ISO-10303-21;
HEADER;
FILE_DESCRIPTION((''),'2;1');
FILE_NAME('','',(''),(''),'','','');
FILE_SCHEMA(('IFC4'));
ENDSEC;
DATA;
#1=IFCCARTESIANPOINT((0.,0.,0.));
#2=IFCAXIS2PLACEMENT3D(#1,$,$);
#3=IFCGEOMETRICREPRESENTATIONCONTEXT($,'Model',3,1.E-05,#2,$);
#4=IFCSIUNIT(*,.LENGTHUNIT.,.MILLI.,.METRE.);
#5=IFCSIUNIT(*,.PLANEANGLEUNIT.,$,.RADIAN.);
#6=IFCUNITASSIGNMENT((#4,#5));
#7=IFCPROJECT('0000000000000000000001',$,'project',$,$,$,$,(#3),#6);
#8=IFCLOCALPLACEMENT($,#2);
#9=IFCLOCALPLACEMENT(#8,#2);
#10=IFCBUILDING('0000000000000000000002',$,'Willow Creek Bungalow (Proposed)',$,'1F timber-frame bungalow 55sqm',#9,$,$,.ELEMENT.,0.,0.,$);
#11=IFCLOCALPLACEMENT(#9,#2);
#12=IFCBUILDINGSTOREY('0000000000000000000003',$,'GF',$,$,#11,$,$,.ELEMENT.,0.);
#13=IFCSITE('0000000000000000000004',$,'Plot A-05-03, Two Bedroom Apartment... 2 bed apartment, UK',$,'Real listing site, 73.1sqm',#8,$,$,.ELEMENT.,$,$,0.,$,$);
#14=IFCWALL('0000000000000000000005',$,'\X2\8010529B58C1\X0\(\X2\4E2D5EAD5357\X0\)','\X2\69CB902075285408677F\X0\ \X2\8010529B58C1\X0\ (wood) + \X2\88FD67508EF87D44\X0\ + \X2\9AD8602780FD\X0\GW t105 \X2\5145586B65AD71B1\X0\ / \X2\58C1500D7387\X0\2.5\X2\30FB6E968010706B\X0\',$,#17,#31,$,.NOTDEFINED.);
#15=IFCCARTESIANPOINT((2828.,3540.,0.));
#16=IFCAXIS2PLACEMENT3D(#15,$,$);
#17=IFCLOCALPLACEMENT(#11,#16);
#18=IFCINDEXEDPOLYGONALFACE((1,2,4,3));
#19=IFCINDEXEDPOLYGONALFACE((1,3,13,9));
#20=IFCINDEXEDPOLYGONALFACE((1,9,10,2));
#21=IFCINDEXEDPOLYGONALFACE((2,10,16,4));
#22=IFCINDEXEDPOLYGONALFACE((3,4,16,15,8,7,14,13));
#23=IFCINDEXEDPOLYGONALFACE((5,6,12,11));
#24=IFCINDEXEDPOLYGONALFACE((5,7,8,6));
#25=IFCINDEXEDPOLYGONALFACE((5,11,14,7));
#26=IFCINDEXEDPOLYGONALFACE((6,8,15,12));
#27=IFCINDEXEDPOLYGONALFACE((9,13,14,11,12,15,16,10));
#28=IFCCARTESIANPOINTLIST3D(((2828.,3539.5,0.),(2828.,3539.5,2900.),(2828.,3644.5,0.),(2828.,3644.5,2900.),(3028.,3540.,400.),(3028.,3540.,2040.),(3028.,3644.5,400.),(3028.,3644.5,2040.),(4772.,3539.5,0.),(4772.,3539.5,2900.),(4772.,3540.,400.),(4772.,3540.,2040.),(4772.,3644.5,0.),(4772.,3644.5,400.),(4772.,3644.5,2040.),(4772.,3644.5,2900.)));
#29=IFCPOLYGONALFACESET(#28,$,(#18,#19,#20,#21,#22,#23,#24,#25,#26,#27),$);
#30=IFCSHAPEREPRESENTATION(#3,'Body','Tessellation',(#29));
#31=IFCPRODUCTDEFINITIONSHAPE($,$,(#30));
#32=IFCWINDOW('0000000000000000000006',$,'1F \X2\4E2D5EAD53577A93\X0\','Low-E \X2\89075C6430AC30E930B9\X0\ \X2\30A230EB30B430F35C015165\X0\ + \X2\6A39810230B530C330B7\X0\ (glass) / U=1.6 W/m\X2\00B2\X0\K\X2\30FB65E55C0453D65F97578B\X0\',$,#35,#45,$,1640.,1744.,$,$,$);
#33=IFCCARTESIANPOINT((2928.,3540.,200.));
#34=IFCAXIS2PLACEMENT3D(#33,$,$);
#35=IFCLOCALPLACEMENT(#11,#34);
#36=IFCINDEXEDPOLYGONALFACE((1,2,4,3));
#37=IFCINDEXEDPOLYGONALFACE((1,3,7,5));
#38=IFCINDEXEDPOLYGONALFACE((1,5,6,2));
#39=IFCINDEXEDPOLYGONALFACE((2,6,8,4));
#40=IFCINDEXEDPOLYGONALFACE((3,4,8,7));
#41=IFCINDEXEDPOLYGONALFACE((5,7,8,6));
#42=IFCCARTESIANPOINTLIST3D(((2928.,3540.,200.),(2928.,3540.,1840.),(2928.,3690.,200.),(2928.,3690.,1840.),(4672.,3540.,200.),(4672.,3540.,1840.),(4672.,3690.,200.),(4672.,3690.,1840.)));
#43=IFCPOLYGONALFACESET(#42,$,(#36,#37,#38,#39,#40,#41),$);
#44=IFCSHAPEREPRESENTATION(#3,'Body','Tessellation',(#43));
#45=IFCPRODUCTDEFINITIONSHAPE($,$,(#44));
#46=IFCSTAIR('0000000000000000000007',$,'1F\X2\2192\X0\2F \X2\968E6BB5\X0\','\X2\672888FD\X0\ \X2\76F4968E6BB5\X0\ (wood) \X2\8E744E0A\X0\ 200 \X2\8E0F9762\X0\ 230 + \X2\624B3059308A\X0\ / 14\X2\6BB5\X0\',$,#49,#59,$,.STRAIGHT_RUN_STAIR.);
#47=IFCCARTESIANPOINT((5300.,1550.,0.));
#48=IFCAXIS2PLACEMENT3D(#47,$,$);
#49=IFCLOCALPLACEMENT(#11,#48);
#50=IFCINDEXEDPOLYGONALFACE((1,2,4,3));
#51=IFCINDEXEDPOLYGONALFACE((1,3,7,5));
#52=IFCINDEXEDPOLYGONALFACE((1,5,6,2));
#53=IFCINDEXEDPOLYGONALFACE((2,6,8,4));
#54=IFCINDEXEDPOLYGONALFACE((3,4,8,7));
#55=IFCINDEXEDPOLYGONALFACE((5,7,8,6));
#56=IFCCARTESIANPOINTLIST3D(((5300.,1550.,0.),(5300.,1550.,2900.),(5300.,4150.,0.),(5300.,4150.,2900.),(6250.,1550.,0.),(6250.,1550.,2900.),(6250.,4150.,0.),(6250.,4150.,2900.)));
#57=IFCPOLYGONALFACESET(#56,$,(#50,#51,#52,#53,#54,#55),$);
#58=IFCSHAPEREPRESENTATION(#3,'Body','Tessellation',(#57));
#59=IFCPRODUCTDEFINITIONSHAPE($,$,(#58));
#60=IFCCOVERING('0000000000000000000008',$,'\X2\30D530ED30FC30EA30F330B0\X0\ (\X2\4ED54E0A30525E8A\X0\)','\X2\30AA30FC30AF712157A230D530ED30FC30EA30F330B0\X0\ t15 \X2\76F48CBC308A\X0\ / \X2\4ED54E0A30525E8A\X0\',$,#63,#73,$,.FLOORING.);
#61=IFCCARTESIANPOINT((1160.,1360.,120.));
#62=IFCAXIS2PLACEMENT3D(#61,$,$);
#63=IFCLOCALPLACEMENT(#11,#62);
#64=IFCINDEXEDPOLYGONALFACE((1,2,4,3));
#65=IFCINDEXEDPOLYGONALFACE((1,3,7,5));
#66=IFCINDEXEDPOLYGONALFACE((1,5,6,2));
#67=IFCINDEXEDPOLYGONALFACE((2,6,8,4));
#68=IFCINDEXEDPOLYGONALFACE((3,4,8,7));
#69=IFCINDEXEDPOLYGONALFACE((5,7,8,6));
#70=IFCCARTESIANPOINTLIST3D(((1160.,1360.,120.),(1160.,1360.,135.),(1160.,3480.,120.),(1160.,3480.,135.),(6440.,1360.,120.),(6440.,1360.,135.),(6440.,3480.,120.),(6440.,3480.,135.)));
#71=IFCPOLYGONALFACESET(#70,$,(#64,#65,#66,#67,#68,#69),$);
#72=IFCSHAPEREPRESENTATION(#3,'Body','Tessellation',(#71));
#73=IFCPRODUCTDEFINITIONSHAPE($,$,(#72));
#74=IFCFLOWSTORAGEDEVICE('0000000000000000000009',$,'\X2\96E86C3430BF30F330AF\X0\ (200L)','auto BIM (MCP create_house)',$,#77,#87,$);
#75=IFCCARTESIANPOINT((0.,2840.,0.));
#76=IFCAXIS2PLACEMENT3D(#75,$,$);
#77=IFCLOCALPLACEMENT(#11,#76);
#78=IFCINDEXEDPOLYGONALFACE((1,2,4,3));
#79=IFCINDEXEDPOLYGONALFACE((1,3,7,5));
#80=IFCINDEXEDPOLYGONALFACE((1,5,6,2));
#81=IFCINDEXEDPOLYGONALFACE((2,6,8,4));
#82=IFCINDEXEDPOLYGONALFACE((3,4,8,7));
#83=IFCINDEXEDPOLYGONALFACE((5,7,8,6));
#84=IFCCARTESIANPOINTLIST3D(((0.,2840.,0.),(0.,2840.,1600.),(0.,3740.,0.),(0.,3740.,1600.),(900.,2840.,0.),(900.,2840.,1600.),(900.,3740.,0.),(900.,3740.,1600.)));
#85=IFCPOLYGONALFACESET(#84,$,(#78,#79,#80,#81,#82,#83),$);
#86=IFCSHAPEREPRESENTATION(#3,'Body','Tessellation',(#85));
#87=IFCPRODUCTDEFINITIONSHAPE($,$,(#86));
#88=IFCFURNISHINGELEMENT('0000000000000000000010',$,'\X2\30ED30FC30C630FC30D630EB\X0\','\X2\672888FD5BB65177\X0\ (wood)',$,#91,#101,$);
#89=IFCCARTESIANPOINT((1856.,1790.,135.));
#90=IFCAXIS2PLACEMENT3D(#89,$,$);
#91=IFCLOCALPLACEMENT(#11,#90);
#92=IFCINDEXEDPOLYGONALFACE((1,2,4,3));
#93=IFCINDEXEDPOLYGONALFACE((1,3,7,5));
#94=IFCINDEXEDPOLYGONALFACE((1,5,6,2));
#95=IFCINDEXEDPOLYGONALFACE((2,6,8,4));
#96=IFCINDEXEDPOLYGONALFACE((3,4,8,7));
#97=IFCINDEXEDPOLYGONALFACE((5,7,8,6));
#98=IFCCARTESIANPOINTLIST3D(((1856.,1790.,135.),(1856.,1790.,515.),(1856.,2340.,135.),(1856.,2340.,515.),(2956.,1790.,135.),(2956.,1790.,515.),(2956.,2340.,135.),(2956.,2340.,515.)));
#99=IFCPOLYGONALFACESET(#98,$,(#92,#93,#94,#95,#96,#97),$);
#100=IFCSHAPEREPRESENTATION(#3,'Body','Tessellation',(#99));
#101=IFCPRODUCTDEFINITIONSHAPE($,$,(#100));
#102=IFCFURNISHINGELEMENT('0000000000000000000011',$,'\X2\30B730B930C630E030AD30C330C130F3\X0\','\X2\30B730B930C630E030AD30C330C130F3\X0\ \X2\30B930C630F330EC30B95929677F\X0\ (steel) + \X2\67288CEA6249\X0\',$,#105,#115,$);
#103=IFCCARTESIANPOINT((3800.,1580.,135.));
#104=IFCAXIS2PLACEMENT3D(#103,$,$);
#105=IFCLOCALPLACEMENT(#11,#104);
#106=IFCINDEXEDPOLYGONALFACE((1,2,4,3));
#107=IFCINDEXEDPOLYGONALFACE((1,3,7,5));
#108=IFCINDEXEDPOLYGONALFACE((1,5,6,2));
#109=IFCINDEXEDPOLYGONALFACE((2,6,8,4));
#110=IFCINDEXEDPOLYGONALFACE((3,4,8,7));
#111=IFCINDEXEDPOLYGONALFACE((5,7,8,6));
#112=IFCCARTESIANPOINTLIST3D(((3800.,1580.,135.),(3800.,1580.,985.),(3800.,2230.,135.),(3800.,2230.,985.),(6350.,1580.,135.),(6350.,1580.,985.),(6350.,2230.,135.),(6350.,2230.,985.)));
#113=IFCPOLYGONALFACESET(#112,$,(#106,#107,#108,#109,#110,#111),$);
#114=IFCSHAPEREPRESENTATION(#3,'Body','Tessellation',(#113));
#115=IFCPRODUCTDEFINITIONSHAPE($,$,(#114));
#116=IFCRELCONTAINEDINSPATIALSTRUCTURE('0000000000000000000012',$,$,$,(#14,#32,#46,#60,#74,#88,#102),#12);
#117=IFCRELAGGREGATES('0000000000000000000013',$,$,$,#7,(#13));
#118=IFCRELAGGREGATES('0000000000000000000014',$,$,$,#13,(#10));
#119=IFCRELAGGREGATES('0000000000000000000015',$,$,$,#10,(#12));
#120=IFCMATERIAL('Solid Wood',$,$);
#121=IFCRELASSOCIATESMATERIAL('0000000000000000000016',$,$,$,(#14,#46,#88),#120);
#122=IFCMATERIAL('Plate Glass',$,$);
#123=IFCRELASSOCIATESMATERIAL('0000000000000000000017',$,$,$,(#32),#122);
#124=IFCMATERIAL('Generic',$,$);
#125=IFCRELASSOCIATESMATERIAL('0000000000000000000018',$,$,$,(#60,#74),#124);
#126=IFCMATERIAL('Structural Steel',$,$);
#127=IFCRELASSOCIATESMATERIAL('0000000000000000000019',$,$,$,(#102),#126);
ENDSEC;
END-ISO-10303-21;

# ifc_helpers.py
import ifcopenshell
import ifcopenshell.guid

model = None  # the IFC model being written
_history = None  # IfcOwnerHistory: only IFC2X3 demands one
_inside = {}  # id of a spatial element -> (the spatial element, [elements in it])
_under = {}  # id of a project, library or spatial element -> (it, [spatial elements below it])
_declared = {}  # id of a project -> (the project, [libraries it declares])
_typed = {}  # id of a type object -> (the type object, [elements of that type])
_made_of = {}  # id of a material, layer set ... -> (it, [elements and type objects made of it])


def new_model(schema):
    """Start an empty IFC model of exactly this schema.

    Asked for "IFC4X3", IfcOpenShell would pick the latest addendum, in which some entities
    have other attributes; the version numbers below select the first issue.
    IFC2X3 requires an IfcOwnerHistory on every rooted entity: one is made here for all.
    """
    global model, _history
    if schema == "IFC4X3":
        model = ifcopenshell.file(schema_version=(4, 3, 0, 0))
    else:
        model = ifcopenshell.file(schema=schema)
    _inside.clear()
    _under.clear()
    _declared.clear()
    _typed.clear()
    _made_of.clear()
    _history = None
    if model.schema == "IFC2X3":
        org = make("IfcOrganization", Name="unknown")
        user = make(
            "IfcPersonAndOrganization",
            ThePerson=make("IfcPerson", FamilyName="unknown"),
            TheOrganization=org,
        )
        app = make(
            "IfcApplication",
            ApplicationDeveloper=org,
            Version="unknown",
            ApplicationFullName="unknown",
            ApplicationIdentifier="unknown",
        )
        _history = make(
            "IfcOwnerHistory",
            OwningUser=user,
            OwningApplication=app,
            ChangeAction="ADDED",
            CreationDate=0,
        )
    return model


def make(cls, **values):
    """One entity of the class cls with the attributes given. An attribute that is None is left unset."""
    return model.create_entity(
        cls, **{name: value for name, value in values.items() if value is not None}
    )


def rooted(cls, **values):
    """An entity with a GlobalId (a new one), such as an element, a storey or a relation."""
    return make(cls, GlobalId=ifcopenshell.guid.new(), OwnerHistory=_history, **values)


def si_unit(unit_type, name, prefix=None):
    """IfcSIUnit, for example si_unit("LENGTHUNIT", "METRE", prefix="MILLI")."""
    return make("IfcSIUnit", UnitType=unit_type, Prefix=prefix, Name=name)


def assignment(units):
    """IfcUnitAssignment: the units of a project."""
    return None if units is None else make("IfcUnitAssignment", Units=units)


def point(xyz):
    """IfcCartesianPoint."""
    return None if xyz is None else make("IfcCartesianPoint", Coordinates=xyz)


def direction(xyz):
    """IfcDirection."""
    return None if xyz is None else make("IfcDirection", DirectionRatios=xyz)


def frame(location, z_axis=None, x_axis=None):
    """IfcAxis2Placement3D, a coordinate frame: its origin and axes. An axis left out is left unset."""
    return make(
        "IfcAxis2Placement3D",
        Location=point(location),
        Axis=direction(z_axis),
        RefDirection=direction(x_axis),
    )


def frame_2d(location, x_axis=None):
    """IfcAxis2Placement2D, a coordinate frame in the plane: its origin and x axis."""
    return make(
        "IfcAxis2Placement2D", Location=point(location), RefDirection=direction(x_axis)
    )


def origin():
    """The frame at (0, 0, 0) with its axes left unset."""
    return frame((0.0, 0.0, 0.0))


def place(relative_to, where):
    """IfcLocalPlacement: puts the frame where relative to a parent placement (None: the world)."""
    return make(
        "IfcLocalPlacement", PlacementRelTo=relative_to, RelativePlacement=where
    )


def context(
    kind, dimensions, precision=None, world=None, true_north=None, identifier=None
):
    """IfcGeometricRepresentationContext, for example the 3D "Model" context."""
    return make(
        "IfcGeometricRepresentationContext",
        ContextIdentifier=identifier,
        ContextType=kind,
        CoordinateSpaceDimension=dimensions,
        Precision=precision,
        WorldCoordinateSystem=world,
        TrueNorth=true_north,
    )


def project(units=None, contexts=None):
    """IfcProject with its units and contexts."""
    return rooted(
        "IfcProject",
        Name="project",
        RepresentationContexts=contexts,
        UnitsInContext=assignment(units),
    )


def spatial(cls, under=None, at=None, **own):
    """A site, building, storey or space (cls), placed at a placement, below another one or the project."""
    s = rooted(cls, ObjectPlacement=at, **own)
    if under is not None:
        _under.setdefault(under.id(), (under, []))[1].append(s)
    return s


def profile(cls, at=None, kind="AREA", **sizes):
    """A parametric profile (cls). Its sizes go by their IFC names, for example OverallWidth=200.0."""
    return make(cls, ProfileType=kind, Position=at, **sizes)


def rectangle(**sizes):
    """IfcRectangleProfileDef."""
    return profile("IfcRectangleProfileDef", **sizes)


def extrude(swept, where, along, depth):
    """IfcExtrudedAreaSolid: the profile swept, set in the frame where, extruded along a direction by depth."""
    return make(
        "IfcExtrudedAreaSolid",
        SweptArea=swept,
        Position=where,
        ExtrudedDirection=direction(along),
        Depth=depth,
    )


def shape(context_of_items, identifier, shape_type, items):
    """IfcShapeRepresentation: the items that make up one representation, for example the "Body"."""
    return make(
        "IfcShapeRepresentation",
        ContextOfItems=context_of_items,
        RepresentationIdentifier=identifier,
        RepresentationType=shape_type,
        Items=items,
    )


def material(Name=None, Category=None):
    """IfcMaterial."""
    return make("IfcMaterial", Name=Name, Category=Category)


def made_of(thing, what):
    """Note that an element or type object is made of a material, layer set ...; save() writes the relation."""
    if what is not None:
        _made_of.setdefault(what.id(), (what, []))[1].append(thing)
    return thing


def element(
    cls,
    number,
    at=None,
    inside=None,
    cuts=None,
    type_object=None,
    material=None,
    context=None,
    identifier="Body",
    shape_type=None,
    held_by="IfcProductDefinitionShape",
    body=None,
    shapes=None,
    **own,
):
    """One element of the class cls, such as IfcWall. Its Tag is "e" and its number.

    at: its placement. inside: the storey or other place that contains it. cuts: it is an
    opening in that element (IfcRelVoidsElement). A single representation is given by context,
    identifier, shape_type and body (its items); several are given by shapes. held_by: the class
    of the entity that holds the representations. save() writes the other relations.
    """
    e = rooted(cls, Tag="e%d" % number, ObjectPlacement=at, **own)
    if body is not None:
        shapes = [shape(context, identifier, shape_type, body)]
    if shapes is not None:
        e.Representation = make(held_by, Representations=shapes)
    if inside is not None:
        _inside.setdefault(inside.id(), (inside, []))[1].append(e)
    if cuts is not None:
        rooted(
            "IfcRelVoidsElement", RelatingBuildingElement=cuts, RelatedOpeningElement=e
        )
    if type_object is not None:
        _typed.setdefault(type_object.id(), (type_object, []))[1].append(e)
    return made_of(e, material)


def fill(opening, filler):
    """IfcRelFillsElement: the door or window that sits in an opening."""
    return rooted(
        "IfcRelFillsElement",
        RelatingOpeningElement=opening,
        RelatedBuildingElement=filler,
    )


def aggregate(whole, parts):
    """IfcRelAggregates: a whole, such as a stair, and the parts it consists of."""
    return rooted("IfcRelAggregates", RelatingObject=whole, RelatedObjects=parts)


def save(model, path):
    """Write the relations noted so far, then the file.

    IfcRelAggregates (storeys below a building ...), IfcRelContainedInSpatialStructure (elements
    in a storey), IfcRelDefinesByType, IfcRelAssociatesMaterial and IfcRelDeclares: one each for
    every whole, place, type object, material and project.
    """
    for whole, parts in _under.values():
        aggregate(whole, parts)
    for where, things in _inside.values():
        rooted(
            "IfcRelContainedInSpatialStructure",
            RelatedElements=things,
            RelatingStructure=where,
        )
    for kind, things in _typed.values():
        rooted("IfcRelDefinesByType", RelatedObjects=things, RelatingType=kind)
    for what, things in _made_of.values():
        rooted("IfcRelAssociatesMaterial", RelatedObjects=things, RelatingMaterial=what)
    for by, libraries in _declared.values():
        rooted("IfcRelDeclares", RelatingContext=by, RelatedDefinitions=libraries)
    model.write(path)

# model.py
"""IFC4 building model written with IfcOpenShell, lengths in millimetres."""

from ifc_helpers import new_model, si_unit, frame, frame_2d, origin, place, context, project, spatial, rectangle, extrude, material, element, fill, save


model = new_model("IFC4")

# Units and contexts
model_context = context("Model", 3, precision=1e-05, world=origin())
ifc_project = project(units=[si_unit("LENGTHUNIT", "METRE", prefix="MILLI"), si_unit("PLANEANGLEUNIT", "RADIAN")], contexts=[model_context])

# Site, building, storey
site_placement = place(None, origin())
site = spatial("IfcSite", under=ifc_project, at=site_placement, Name="Plot A-05-03, Two Bedroom Apartment... 2 bed apartment, UK", ObjectType="Real listing site, 73.1sqm", CompositionType="ELEMENT", RefElevation=0.0)
building_placement = place(site_placement, origin())
building = spatial("IfcBuilding", under=site, at=building_placement, Name="Willow Creek Bungalow (Proposed)", ObjectType="1F timber-frame bungalow 55sqm", CompositionType="ELEMENT", ElevationOfRefHeight=0.0, ElevationOfTerrain=0.0)
storey_placement = place(building_placement, origin())
storey = spatial("IfcBuildingStorey", under=building, at=storey_placement, Name="GF", CompositionType="ELEMENT", Elevation=0.0)

# Shared definitions
ifc_material_1 = material(Name="Solid Wood")

# Shared definitions
ifc_material_2 = material(Name="Plate Glass")

# Wall, opening, window
wall_1_placement = place(storey_placement, frame((2828.0, 3540.0, 0.0)))
wall_1 = element("IfcWall", 1, at=wall_1_placement, inside=storey, material=ifc_material_1, Name="耐力壁(中庭南)", Description="構造用合板 耐力壁 (wood) + 製材軸組 + 高性能GW t105 充填断熱 / 壁倍率2.5・準耐火", PredefinedType="NOTDEFINED", context=model_context, shape_type="SweptSolid", body=[
    extrude(rectangle(XDim=1944.0, YDim=105.0, at=frame_2d((972.0, 52.0))), frame((2828.0, 3540.0, 0.0)), (0.0, 0.0, 1.0), 2900.0),
])
opening_1_placement = place(storey_placement, frame((2928.0, 3540.0, 200.0)))
opening_1 = element("IfcOpeningElement", 2, at=opening_1_placement, cuts=wall_1, PredefinedType="NOTDEFINED", context=model_context, shape_type="SweptSolid", body=[
    extrude(rectangle(XDim=1744.0, YDim=150.0, at=frame_2d((872.0, 75.0))), frame((2928.0, 3540.0, 200.0)), (0.0, 0.0, 1.0), 1640.0),
])
window_1_placement = place(storey_placement, frame((2928.0, 3540.0, 200.0)))
window_1 = element("IfcWindow", 3, at=window_1_placement, inside=storey, material=ifc_material_2, Name="1F 中庭南窓", Description="Low-E 複層ガラス アルゴン封入 + 樹脂サッシ (glass) / U=1.6 W/m²K・日射取得型", OverallHeight=1640.0, OverallWidth=1744.0, context=model_context, shape_type="SweptSolid", body=[
    extrude(rectangle(XDim=1744.0, YDim=150.0, at=frame_2d((872.0, 75.0))), frame((2928.0, 3540.0, 200.0)), (0.0, 0.0, 1.0), 1640.0),
])
fill(opening_1, window_1)

# Stair
stair_placement = place(storey_placement, frame((5300.0, 1550.0, 0.0)))
element("IfcStair", 4, at=stair_placement, inside=storey, material=ifc_material_1, Name="1F→2F 階段", Description="木製 直階段 (wood) 蹴上 200 踏面 230 + 手すり / 14段", PredefinedType="STRAIGHT_RUN_STAIR", context=model_context, shape_type="SweptSolid", body=[
    extrude(rectangle(XDim=950.0, YDim=2600.0, at=frame_2d((475.0, 1300.0))), frame((5300.0, 1550.0, 0.0)), (0.0, 0.0, 1.0), 2900.0),
])

# Covering
ifc_material_3 = material(Name="Generic")
covering_placement = place(storey_placement, frame((1160.0, 1360.0, 120.0)))
element("IfcCovering", 5, at=covering_placement, inside=storey, material=ifc_material_3, Name="フローリング (仕上げ床)", Description="オーク無垢フローリング t15 直貼り / 仕上げ床", PredefinedType="FLOORING", context=model_context, shape_type="SweptSolid", body=[
    extrude(rectangle(XDim=5280.0, YDim=2120.0, at=frame_2d((2640.0, 1060.0))), frame((1160.0, 1360.0, 120.0)), (0.0, 0.0, 1.0), 15.0),
])

# Flow storage device
flow_storage_device_placement = place(storey_placement, frame((0.0, 2840.0, 0.0)))
element("IfcFlowStorageDevice", 6, at=flow_storage_device_placement, inside=storey, material=ifc_material_3, Name="雨水タンク (200L)", Description="auto BIM (MCP create_house)", context=model_context, shape_type="SweptSolid", body=[
    extrude(rectangle(XDim=900.0, YDim=900.0, at=frame_2d((450.0, 450.0))), frame((0.0, 2840.0, 0.0)), (0.0, 0.0, 1.0), 1600.0),
])

# Furnishing elements
furnishing_1_placement = place(storey_placement, frame((1856.0, 1790.0, 135.0)))
element("IfcFurnishingElement", 7, at=furnishing_1_placement, inside=storey, material=ifc_material_1, Name="ローテーブル", Description="木製家具 (wood)", context=model_context, shape_type="SweptSolid", body=[
    extrude(rectangle(XDim=1100.0, YDim=550.0, at=frame_2d((550.0, 275.0))), frame((1856.0, 1790.0, 135.0)), (0.0, 0.0, 1.0), 380.0),
])
ifc_material_4 = material(Name="Structural Steel")
furnishing_2_placement = place(storey_placement, frame((3800.0, 1580.0, 135.0)))
element("IfcFurnishingElement", 8, at=furnishing_2_placement, inside=storey, material=ifc_material_4, Name="システムキッチン", Description="システムキッチン ステンレス天板 (steel) + 木質扉", context=model_context, shape_type="SweptSolid", body=[
    extrude(rectangle(XDim=2550.0, YDim=650.0, at=frame_2d((1275.0, 325.0))), frame((3800.0, 1580.0, 135.0)), (0.0, 0.0, 1.0), 850.0),
])

save(model, "model.ifc")
